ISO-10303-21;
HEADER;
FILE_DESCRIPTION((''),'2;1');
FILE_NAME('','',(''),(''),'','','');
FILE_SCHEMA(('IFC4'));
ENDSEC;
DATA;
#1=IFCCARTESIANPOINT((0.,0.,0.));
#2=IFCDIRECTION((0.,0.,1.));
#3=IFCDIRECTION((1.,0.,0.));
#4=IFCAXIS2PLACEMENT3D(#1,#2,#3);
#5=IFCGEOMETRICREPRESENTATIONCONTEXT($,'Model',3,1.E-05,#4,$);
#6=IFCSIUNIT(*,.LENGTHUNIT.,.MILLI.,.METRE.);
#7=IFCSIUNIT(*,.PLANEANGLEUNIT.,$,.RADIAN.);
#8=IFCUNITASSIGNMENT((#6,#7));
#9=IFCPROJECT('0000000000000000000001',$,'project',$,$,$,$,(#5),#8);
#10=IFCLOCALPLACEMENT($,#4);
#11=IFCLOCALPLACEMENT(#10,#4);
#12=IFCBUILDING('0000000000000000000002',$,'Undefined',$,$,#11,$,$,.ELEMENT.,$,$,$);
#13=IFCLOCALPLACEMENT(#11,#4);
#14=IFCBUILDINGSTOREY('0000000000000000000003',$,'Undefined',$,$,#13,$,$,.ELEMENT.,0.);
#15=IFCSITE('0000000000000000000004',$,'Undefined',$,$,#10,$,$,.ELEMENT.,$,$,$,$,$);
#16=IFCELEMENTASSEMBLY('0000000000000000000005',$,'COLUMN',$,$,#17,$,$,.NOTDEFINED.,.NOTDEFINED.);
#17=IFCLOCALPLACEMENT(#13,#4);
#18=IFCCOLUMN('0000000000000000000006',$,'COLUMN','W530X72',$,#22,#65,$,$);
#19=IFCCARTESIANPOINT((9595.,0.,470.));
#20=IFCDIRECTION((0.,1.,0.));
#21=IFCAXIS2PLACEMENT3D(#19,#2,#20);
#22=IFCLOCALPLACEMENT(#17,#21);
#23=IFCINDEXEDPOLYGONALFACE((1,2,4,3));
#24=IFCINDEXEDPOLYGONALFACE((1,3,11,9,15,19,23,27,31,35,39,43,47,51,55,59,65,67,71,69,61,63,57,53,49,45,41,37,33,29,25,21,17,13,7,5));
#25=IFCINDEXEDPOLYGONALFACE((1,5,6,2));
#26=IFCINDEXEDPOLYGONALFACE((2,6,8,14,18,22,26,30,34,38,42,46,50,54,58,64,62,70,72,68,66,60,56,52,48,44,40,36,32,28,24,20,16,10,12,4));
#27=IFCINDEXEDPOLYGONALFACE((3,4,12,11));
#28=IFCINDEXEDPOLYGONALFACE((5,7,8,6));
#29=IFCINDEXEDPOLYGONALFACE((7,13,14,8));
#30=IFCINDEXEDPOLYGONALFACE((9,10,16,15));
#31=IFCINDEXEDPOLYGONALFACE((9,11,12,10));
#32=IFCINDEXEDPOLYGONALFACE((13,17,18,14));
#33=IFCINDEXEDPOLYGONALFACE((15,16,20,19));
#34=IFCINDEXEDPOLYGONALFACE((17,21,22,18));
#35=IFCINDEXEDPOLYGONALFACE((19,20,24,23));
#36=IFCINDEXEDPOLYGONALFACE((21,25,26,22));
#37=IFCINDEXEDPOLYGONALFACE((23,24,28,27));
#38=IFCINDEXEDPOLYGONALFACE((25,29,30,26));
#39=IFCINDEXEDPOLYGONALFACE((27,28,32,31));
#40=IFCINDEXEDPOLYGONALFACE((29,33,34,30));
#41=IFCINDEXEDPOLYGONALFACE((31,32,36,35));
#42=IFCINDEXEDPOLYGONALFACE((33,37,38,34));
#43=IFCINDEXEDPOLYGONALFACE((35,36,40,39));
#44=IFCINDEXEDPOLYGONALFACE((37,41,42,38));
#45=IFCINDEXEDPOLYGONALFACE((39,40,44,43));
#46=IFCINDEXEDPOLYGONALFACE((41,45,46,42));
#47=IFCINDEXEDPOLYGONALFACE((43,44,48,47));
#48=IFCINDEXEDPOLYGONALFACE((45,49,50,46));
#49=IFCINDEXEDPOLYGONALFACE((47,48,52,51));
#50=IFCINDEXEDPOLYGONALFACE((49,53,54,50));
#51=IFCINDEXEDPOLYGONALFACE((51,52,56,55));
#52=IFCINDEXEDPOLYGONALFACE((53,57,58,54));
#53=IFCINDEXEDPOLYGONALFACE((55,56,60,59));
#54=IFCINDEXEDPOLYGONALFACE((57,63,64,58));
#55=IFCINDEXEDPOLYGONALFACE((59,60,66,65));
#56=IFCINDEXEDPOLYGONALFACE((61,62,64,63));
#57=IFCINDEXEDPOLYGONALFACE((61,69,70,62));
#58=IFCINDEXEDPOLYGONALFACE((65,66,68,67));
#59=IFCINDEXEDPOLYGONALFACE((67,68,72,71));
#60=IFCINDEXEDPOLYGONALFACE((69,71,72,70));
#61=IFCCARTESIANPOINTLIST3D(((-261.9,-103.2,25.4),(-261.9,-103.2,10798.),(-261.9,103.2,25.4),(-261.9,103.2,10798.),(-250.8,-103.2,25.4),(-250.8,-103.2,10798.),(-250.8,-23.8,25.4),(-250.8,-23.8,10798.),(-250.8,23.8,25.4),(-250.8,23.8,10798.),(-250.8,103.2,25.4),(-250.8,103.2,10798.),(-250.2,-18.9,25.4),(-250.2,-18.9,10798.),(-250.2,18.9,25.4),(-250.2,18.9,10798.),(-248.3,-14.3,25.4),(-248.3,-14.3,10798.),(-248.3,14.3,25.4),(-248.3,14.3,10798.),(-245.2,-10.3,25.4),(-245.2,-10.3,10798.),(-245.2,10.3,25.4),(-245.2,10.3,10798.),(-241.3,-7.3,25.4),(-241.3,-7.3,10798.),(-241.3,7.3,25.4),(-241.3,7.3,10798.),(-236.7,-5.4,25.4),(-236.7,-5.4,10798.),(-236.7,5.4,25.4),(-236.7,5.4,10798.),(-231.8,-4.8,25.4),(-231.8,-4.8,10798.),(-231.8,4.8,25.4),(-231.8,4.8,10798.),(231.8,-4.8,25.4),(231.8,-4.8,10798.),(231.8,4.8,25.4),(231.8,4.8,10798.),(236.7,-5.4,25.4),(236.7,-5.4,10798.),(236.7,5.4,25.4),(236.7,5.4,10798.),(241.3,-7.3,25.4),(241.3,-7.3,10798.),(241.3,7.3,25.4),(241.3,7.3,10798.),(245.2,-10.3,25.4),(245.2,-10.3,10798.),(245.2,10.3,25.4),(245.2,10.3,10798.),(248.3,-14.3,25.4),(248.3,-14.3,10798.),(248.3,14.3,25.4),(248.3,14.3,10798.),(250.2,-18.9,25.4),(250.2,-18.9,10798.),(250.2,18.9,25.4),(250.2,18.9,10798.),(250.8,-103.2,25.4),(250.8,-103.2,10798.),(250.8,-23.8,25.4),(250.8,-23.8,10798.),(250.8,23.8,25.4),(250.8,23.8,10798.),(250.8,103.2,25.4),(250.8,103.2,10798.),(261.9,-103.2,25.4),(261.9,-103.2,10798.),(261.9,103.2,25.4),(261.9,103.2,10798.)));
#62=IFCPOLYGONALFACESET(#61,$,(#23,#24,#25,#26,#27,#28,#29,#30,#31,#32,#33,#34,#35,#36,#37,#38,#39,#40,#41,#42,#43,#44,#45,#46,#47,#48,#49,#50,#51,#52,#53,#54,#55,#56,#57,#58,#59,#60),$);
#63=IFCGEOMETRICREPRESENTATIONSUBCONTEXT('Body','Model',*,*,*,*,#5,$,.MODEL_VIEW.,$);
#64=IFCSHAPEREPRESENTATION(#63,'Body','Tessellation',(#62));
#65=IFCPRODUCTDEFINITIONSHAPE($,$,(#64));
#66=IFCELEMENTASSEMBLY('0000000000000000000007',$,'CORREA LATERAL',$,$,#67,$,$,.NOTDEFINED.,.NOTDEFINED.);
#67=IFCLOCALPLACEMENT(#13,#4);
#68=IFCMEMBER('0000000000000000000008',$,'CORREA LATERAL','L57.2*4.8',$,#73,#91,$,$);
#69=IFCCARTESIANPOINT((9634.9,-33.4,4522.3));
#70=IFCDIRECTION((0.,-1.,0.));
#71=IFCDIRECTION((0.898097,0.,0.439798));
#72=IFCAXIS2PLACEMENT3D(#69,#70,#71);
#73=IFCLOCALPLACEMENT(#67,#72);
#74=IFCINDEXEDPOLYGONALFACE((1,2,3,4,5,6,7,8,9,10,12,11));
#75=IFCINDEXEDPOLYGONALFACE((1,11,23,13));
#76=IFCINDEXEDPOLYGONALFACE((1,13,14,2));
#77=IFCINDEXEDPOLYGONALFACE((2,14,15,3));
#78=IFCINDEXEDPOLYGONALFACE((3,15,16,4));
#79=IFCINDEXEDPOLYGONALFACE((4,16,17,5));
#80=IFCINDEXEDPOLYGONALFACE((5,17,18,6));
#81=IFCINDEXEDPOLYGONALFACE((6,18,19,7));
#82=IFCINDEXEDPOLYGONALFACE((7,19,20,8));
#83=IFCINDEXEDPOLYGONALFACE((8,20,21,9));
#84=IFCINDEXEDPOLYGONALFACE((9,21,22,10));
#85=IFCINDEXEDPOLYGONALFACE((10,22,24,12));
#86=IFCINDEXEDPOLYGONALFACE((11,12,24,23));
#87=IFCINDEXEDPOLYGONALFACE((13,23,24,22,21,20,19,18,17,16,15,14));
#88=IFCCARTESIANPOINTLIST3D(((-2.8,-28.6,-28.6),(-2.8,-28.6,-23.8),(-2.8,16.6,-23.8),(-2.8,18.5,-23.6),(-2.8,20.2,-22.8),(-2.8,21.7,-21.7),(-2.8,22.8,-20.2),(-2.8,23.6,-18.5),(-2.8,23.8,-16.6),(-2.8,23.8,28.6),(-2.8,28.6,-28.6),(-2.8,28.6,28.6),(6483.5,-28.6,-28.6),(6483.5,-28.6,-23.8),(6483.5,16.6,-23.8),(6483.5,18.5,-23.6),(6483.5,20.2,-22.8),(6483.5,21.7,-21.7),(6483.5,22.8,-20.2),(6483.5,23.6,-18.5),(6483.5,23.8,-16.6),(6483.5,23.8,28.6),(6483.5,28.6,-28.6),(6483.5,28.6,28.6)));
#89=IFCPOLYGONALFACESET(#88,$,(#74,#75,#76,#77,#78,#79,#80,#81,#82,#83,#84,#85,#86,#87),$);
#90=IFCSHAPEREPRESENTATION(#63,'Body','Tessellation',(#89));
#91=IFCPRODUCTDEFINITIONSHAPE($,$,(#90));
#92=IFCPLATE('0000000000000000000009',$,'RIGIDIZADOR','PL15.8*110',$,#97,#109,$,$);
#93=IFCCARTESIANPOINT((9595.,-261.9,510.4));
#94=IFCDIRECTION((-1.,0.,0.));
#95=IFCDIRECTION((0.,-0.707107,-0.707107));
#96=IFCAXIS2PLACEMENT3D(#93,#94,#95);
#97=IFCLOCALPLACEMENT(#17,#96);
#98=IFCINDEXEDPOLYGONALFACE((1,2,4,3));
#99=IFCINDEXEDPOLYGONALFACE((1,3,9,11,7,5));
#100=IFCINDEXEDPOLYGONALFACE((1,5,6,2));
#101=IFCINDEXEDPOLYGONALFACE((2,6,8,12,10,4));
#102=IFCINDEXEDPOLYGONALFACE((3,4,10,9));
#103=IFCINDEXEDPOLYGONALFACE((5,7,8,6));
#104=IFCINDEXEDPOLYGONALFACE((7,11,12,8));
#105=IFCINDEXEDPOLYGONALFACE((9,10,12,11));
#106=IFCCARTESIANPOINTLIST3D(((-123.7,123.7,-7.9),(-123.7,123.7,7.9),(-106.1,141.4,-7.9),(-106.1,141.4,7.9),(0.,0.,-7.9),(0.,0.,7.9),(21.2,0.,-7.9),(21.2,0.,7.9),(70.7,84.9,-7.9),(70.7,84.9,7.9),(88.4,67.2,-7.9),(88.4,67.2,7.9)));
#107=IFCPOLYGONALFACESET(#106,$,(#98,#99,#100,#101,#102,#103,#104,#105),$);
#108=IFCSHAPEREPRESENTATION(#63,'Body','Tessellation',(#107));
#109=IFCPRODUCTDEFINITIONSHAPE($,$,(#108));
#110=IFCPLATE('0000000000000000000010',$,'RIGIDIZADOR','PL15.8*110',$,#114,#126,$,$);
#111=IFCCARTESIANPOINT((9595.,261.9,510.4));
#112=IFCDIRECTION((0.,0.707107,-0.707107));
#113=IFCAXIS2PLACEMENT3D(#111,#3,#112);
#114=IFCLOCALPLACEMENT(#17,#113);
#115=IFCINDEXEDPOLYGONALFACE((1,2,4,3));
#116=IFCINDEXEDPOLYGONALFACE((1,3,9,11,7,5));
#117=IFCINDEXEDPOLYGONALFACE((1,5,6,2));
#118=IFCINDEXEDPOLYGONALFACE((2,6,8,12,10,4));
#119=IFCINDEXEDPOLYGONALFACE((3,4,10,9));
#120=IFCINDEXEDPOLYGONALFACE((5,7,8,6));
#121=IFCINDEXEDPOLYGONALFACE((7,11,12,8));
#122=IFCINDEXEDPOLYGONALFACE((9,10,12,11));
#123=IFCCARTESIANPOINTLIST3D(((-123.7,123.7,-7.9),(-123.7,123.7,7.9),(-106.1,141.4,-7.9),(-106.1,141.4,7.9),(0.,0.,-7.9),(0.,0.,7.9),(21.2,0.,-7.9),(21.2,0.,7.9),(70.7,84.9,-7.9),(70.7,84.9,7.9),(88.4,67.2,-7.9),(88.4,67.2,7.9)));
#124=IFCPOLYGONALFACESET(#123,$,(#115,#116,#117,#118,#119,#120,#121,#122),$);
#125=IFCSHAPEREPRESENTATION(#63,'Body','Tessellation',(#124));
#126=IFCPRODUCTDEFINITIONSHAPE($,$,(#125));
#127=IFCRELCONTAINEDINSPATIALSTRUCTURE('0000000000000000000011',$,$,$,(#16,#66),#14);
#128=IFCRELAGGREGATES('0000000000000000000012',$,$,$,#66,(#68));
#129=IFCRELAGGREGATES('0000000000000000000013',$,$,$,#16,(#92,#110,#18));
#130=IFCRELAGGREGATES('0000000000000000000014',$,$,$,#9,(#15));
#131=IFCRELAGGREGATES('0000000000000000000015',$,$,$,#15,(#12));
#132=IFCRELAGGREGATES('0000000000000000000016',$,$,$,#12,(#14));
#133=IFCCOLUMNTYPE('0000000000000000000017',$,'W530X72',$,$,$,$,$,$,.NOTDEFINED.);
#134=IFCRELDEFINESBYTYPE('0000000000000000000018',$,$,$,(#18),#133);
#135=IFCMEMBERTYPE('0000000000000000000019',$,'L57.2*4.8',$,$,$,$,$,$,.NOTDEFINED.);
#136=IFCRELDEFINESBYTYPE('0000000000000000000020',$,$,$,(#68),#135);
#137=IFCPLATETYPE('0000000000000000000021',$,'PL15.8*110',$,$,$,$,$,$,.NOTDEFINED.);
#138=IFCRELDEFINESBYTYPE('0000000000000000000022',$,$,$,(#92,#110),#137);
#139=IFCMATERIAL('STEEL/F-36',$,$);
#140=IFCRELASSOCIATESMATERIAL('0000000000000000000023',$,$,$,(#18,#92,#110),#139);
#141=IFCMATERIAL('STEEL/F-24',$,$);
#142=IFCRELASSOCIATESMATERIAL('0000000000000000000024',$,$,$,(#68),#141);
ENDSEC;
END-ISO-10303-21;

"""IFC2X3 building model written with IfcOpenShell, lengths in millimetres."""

from ifc_helpers import new_model, si_unit, frame, origin_with_axes, origin_2d_with_axis, place, context, subcontext, project, spatial, polyline, i_section, l_section, outline, extrude, clip, halfspace, material, type_object, element, aggregate, save


model = new_model("IFC2X3")

# Units and contexts
model_context = context("Model", 3, precision=1e-05, world=origin_with_axes())
body_context = subcontext(model_context, "Body", "Model", "MODEL_VIEW")
ifc_project = project(units=[si_unit("LENGTHUNIT", "METRE", prefix="MILLI"), si_unit("PLANEANGLEUNIT", "RADIAN")], contexts=[model_context])

# Site, building, storey
site_placement = place(None, origin_with_axes())
site = spatial("IfcSite", under=ifc_project, at=site_placement, Name="Undefined", CompositionType="ELEMENT")
building_placement = place(site_placement, origin_with_axes())
building = spatial("IfcBuilding", under=site, at=building_placement, Name="Undefined", CompositionType="ELEMENT")
storey_placement = place(building_placement, origin_with_axes())
storey = spatial("IfcBuildingStorey", under=building, at=storey_placement, Name="Undefined", CompositionType="ELEMENT", Elevation=0.0)

# Element assembly, column
assembly_1_placement = place(storey_placement, origin_with_axes())
assembly_1 = element("IfcElementAssembly", 1, at=assembly_1_placement, inside=storey, Name="COLUMN", AssemblyPlace="NOTDEFINED", PredefinedType="NOTDEFINED")
ifc_material_1 = material(Name="STEEL/F-36")
column_type = type_object("IfcColumnType", Name="W530X72", PredefinedType="NOTDEFINED")
column_placement = place(assembly_1_placement, frame((9595.0, 0.0, 470.0), z_axis=(0.0, 0.0, 1.0), x_axis=(0.0, 1.0, 0.0)))
column = element("IfcColumn", 2, at=column_placement, type_object=column_type, material=ifc_material_1, Name="COLUMN", Description="W530X72", context=body_context, shape_type="Clipping", body=[
    clip(extrude(i_section(OverallWidth=206.4, OverallDepth=523.9, WebThickness=9.5, FlangeThickness=11.1, FilletRadius=19.0, at=origin_2d_with_axis()), frame((0.0, 0.0, 10798.0), z_axis=(0.0, 0.0, -1.0), x_axis=(0.0, 1.0, 0.0)), (0.0, 0.0, 1.0), 10798.0), halfspace(frame((-261.9, 0.0, 25.4), z_axis=(0.0, 0.0, 1.0), x_axis=(0.0, 1.0, 0.0)), True)),
])

# Element assembly, member
assembly_2_placement = place(storey_placement, origin_with_axes())
assembly_2 = element("IfcElementAssembly", 3, at=assembly_2_placement, inside=storey, Name="CORREA LATERAL", AssemblyPlace="NOTDEFINED", PredefinedType="NOTDEFINED")
ifc_material_2 = material(Name="STEEL/F-24")
member_type = type_object("IfcMemberType", Name="L57.2*4.8", PredefinedType="NOTDEFINED")
member_1_placement = place(assembly_2_placement, frame((9634.9, -33.4, 4522.3), z_axis=(0.0, -1.0, 0.0), x_axis=(0.898097, 0.0, 0.439798)))
member_1 = element("IfcMember", 4, at=member_1_placement, type_object=member_type, material=ifc_material_2, Name="CORREA LATERAL", Description="L57.2*4.8", context=body_context, shape_type="Clipping", body=[
    clip(clip(extrude(l_section(Depth=57.2, Width=57.2, Thickness=4.8, FilletRadius=7.2, at=origin_2d_with_axis()), frame((6529.1, 0.0, 0.0), z_axis=(-1.0, 0.0, 0.0), x_axis=(0.0, -1.0, 0.0)), (0.0, 0.0, 1.0), 6577.6), halfspace(frame((6483.5, 0.0, -28.6), z_axis=(-1.0, 0.0, 0.0), x_axis=(0.0, -1.0, 0.0)), True)), halfspace(frame((-2.8, 0.0, -28.6), z_axis=(1.0, 0.0, 0.0), x_axis=(0.0, 1.0, 0.0)), True)),
])

# Plates
plate_type_1 = type_object("IfcPlateType", Name="PL15.8*110", PredefinedType="NOTDEFINED")
plate_1_placement = place(assembly_1_placement, frame((9595.0, -261.9, 510.4), z_axis=(-1.0, 0.0, 0.0), x_axis=(0.0, -0.707107, -0.707107)))
plate_1 = element("IfcPlate", 5, at=plate_1_placement, type_object=plate_type_1, material=ifc_material_1, Name="RIGIDIZADOR", Description="PL15.8*110", context=body_context, shape_type="SweptSolid", body=[
    extrude(outline(polyline([(0.0, 0.0), (21.2, 0.0), (88.4, 67.2), (70.7, 84.9), (-106.1, 141.4), (-123.7, 123.7), (0.0, 0.0)])), frame((0.0, 0.0, -7.9), z_axis=(0.0, 0.0, 1.0), x_axis=(1.0, 0.0, 0.0)), (0.0, 0.0, 1.0), 15.8),
])
plate_2_placement = place(assembly_1_placement, frame((9595.0, 261.9, 510.4), z_axis=(1.0, 0.0, 0.0), x_axis=(0.0, 0.707107, -0.707107)))
plate_2 = element("IfcPlate", 6, at=plate_2_placement, type_object=plate_type_1, material=ifc_material_1, Name="RIGIDIZADOR", Description="PL15.8*110", context=body_context, shape_type="SweptSolid", body=[
    extrude(outline(polyline([(0.0, 0.0), (21.2, 0.0), (88.4, 67.2), (70.7, 84.9), (-106.1, 141.4), (-123.7, 123.7), (0.0, 0.0)])), frame((0.0, 0.0, -7.9), z_axis=(0.0, 0.0, 1.0), x_axis=(1.0, 0.0, 0.0)), (0.0, 0.0, 1.0), 15.8),
])

aggregate(assembly_2, [member_1])
aggregate(assembly_1, [plate_1, plate_2, column])

save(model, "model.ifc")
